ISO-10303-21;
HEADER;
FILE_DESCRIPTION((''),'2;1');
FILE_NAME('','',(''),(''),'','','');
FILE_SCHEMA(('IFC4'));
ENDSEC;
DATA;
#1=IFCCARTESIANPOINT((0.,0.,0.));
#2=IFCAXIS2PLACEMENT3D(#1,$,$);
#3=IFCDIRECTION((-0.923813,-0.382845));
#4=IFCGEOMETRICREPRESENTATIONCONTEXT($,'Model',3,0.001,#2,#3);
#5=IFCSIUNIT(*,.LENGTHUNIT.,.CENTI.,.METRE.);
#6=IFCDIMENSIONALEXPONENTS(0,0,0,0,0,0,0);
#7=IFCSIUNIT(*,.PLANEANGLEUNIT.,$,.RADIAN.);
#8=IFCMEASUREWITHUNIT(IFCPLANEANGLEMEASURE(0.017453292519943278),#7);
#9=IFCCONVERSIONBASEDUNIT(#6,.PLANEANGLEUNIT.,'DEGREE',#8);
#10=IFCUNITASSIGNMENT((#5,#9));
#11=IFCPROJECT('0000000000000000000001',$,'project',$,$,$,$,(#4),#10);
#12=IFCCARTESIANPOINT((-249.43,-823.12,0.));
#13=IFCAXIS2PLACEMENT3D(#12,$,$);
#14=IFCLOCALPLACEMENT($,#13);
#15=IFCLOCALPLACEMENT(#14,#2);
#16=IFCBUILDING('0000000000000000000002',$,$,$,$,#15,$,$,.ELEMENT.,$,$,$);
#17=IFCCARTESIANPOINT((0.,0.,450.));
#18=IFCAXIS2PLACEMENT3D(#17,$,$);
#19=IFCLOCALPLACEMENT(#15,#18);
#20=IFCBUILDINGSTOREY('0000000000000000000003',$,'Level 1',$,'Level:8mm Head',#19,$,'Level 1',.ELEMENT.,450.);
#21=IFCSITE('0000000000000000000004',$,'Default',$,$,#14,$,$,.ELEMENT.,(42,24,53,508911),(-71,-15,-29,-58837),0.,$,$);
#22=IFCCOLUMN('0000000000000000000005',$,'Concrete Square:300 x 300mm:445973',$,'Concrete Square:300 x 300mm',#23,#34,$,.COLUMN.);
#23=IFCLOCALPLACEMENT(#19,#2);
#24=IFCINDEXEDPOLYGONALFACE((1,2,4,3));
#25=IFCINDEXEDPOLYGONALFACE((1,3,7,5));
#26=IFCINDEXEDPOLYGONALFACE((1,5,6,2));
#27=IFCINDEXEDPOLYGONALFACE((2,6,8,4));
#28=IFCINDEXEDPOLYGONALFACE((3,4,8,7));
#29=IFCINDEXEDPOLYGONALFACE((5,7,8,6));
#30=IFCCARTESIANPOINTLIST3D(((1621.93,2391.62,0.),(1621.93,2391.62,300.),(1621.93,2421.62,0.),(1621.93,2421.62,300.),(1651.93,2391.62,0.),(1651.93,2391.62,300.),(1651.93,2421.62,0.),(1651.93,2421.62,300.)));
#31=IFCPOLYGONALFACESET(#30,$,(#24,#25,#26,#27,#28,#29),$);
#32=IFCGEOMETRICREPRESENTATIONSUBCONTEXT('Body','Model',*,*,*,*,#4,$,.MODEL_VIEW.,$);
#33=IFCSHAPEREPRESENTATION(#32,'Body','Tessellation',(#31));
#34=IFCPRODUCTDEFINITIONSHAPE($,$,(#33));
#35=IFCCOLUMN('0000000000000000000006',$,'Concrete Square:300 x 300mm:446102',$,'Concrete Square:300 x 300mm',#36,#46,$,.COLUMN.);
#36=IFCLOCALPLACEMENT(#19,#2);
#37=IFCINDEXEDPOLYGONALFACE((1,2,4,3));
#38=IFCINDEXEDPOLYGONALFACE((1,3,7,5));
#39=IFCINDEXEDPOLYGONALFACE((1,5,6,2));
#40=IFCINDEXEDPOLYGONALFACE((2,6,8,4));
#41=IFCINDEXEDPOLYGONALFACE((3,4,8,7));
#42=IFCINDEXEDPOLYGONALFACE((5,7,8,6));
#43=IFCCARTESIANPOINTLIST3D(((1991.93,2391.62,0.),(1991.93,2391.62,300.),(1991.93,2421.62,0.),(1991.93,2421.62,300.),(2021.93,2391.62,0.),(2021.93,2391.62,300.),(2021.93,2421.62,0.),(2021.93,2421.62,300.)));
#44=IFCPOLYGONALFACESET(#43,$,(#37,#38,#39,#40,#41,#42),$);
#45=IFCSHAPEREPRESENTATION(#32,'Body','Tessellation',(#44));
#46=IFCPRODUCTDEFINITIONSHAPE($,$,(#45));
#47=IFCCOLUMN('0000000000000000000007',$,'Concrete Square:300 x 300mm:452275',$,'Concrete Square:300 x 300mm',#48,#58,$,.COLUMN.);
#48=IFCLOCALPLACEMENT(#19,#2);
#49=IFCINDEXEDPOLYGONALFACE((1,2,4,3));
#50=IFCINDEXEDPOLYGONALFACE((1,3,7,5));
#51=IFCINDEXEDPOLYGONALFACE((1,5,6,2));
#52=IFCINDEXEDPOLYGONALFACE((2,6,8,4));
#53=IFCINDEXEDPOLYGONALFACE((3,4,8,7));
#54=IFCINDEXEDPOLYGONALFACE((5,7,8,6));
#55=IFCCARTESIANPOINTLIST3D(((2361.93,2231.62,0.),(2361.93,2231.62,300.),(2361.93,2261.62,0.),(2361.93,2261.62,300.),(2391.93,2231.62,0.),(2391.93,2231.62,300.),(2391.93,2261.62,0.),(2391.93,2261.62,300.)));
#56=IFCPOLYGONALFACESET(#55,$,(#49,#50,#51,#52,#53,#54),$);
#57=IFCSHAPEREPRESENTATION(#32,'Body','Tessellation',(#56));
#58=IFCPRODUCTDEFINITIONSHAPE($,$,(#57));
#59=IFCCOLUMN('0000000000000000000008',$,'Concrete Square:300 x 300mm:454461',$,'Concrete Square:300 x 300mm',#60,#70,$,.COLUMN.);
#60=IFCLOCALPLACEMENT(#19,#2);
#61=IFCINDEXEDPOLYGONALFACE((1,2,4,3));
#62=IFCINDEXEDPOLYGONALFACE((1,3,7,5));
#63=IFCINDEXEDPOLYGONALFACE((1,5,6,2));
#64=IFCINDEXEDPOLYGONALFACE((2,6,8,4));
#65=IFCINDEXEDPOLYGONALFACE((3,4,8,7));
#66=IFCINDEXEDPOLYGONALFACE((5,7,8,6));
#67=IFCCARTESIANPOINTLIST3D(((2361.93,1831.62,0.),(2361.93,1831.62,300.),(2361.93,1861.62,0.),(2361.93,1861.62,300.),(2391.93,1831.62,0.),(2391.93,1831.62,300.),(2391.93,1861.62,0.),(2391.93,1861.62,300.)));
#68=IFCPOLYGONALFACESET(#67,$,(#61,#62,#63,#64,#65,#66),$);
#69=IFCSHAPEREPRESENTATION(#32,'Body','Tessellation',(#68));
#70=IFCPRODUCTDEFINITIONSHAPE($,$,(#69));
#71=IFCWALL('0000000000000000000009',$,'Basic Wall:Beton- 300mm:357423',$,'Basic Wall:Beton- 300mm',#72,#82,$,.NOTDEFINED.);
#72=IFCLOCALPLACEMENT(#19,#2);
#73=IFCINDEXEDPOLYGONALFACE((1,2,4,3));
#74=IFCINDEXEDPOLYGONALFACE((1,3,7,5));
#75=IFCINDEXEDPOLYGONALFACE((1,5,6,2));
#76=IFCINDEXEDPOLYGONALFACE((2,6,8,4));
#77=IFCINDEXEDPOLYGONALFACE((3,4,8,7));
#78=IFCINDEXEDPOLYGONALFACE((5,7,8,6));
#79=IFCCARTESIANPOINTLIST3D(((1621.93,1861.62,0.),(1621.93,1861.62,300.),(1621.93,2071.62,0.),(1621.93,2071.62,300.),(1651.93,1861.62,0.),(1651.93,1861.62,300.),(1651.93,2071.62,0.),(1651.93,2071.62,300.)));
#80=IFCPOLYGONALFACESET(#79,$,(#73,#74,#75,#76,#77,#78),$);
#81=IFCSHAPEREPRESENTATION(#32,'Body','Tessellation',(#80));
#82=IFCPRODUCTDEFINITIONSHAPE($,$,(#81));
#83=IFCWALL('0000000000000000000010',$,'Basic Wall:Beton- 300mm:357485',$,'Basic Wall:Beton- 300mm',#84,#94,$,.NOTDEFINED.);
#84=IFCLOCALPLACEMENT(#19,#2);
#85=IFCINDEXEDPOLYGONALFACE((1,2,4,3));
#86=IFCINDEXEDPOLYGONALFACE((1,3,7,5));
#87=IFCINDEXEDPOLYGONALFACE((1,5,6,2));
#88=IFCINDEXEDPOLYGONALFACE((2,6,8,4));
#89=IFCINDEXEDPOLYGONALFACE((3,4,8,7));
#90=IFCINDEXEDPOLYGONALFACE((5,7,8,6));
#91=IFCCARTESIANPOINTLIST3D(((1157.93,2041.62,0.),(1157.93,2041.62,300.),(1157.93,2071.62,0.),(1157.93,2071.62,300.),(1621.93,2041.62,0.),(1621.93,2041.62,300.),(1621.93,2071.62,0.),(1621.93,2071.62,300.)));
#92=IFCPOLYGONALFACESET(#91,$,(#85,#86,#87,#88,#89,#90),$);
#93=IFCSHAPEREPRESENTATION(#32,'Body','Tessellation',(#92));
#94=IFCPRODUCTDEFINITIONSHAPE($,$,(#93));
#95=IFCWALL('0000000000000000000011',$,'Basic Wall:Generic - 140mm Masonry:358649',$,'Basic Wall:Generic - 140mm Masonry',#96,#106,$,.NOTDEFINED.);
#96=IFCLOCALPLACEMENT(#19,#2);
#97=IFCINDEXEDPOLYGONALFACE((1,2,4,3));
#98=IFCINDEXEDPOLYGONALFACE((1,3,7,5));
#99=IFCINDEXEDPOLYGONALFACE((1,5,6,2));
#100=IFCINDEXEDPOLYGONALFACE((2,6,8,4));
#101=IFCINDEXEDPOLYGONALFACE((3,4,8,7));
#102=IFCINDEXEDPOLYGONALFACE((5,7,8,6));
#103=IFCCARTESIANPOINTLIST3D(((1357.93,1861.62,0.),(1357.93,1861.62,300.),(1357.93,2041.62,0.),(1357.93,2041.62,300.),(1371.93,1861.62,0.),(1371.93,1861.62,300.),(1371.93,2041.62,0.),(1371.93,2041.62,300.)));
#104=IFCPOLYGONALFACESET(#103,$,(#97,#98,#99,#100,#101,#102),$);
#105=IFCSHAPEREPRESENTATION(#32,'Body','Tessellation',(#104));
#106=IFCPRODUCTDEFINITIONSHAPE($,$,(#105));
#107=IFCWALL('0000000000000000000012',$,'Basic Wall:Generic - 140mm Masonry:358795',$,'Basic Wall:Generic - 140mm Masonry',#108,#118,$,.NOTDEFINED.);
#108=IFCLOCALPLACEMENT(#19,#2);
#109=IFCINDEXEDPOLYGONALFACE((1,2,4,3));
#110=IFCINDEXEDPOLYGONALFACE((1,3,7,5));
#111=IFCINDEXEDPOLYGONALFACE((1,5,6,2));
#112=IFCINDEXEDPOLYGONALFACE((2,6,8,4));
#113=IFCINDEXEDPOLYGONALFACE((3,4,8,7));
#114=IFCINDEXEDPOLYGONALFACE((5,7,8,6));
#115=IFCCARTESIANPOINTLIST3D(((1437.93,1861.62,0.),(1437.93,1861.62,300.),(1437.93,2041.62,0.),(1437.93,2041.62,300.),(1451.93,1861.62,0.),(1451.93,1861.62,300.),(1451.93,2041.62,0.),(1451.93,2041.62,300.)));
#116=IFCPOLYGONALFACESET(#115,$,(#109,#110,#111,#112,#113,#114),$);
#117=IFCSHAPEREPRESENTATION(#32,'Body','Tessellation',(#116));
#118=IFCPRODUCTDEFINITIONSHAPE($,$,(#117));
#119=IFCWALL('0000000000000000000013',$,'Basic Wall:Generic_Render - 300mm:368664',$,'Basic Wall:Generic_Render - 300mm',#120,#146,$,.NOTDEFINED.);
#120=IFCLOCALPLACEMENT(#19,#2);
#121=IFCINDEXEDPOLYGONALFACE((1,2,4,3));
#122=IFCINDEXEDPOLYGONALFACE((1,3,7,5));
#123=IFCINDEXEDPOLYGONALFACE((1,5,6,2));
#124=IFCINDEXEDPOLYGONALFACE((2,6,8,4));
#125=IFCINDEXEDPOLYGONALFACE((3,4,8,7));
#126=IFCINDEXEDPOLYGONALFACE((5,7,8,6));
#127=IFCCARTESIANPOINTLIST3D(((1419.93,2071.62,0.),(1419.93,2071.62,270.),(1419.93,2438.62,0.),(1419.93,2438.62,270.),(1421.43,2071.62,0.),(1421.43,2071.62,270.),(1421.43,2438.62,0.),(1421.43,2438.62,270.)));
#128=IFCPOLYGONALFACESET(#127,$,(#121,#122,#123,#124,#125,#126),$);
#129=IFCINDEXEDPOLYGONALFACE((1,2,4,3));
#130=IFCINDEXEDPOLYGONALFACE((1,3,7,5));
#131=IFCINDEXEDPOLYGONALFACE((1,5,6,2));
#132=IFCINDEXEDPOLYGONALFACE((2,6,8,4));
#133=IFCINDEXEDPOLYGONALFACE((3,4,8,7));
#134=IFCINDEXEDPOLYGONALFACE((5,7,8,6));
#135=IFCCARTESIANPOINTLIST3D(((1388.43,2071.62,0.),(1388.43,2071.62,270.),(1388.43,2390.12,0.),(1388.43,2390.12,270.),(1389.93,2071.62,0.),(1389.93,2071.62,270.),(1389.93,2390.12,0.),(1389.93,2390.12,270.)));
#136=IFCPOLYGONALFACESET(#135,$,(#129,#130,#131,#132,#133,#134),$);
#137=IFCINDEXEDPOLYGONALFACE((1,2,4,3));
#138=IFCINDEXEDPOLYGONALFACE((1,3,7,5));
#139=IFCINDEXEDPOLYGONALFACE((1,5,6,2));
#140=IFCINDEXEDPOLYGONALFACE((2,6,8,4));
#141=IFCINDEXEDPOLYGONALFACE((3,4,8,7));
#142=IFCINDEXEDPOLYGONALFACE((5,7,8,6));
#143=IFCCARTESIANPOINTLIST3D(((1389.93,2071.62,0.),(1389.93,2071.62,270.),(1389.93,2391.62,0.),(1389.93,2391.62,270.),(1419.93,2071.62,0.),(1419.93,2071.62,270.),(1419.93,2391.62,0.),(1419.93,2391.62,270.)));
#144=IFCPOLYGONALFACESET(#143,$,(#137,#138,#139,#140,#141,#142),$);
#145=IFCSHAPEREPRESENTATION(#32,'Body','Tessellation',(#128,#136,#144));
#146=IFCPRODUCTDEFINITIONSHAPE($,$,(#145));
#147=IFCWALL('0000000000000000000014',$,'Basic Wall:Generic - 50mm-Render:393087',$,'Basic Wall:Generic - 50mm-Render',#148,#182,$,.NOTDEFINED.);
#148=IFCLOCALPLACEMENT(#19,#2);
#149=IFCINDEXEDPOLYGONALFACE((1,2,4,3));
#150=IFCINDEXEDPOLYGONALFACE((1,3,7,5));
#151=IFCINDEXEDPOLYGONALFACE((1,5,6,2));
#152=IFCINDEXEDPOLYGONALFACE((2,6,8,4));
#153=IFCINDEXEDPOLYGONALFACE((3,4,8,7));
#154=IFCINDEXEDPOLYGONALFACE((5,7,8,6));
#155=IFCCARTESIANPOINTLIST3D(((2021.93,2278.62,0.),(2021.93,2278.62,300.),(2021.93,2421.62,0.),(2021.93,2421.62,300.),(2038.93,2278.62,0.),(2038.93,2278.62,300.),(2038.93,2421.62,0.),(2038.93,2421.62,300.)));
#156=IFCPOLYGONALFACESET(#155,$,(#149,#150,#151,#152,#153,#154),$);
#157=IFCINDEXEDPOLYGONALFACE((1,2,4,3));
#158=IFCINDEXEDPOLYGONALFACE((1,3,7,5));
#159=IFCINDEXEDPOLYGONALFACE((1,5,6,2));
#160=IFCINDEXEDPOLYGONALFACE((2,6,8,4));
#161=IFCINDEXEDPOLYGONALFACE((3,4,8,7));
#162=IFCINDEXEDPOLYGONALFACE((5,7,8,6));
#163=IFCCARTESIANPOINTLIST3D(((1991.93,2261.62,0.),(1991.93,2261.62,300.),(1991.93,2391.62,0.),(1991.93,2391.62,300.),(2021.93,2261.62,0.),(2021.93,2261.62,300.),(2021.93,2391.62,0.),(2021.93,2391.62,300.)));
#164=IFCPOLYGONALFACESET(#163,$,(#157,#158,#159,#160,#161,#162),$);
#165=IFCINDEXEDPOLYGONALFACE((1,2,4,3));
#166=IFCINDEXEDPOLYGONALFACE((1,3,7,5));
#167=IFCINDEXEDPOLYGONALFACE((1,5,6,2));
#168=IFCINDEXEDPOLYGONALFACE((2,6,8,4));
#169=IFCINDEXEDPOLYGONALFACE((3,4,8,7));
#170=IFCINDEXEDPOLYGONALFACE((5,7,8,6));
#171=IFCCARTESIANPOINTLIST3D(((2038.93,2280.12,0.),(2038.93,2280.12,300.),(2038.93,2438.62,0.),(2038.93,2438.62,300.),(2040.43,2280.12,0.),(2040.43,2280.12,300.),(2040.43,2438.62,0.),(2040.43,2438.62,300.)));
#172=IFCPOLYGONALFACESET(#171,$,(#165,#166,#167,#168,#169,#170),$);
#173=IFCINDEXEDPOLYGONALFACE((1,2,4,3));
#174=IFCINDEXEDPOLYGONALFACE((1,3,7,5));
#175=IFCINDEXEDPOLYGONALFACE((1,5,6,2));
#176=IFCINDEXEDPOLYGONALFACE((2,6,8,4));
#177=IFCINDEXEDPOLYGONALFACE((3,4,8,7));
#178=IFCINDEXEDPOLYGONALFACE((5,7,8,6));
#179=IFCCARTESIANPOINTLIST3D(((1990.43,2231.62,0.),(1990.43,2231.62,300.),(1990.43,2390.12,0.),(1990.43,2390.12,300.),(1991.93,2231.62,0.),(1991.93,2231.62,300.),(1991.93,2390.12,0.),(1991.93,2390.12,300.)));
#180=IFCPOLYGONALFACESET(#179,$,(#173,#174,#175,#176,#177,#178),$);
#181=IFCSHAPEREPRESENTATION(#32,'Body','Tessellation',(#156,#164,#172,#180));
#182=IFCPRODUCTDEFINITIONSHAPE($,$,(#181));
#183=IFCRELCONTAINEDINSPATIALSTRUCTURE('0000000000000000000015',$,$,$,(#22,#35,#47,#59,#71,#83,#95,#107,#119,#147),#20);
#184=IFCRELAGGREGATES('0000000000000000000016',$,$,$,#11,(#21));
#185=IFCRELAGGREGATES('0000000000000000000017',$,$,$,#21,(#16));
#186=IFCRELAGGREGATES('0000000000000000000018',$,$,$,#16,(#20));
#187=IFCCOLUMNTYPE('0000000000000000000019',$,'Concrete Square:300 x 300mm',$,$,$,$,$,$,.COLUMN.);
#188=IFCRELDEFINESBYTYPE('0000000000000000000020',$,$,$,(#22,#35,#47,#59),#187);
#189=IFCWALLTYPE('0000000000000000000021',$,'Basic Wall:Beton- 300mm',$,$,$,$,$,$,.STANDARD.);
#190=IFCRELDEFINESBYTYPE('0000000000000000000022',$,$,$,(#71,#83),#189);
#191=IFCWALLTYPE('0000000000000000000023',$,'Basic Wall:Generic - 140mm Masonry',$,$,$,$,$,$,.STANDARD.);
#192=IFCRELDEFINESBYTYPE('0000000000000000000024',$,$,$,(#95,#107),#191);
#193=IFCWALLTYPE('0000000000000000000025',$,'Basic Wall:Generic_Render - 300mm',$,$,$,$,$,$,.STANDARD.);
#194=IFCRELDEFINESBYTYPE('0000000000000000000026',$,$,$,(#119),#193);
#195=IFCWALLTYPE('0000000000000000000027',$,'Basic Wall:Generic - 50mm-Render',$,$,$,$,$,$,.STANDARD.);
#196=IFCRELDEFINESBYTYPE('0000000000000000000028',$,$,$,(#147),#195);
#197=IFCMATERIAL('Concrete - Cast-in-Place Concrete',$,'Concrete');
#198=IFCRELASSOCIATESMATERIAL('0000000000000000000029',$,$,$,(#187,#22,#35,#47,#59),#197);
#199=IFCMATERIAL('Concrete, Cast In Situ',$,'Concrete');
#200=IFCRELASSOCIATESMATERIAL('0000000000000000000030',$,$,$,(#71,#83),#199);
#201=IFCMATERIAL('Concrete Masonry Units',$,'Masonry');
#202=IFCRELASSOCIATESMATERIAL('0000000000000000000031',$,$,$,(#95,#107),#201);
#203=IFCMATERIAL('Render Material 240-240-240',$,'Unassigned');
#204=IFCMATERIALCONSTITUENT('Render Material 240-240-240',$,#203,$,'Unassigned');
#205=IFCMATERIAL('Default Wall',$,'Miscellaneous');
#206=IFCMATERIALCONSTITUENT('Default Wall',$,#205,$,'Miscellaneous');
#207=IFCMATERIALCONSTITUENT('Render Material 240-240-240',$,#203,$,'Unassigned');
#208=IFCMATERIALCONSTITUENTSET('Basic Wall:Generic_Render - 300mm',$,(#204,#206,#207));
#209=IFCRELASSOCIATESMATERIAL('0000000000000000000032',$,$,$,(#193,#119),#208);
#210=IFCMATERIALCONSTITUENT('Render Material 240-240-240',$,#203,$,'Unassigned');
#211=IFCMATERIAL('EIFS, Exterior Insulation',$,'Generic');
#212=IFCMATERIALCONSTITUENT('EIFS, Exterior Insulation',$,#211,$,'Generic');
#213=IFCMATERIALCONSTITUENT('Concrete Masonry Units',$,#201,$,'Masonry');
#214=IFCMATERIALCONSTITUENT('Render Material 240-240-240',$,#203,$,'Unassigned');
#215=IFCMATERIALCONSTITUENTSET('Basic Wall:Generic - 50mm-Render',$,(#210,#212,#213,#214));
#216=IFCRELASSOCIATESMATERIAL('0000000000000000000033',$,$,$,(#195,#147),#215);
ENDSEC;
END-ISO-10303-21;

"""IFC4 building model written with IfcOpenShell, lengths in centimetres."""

from ifc_helpers import new_model, entity, si_unit, converted_unit, direction, frame, origin, place, context, subcontext, project, spatial, indexed_curve, outline, extrude, source, transform, mapped, material, constituent, constituent_set, type_object, type_shapes, element, save


model = new_model("IFC4")

# Units and contexts
model_context = context("Model", 3, precision=0.001, world=origin(), true_north=direction((-0.923813, -0.382845)))
body_context = subcontext(model_context, "Body", "Model", "MODEL_VIEW")
ifc_project = project(units=[si_unit("LENGTHUNIT", "METRE", prefix="CENTI"), converted_unit("PLANEANGLEUNIT", "DEGREE", entity("IfcPlaneAngleMeasure", 0.017453292519943278), si_unit("PLANEANGLEUNIT", "RADIAN"), dimensions=[0, 0, 0, 0, 0, 0, 0])], contexts=[model_context])

# Site, building, storey
site_placement = place(None, frame((-249.43, -823.12, 0.0)))
site = spatial("IfcSite", under=ifc_project, at=site_placement, Name="Default", CompositionType="ELEMENT", RefLatitude=(42, 24, 53, 508911), RefLongitude=(-71, -15, -29, -58837), RefElevation=0.0)
building_placement = place(site_placement, origin())
building = spatial("IfcBuilding", under=site, at=building_placement, CompositionType="ELEMENT")
storey_placement = place(building_placement, frame((0.0, 0.0, 450.0)))
storey = spatial("IfcBuildingStorey", under=building, at=storey_placement, Name="Level 1", ObjectType="Level:8mm Head", LongName="Level 1", CompositionType="ELEMENT", Elevation=450.0)

# Columns
ifc_material_1 = material(Name="Concrete - Cast-in-Place Concrete", Category="Concrete")
column_type = type_object("IfcColumnType", Name="Concrete Square:300 x 300mm", PredefinedType="COLUMN", material=ifc_material_1)
shared_shape_1 = source(origin(), body_context, "Body", "SweptSolid", [
    extrude(outline(indexed_curve([(-15.0, -15.0), (15.0, -15.0), (15.0, 15.0), (-15.0, 15.0), (-15.0, -15.0)], self_intersect=False)), frame((0.0, 0.0, 450.0), z_axis=(0.0, 0.0, 1.0), x_axis=(-1.0, 0.0, 0.0)), (0.0, 0.0, 1.0), 300.0),
])
type_shapes(column_type, [shared_shape_1])
for number, where, name in (
    (1, (1636.93, 2406.62, -450.0), "Concrete Square:300 x 300mm:445973"),
    (2, (2006.93, 2406.62, -450.0), "Concrete Square:300 x 300mm:446102"),
    (3, (2376.93, 2246.62, -450.0), "Concrete Square:300 x 300mm:452275"),
    (4, (2376.93, 1846.62, -450.0), "Concrete Square:300 x 300mm:454461"),
):
    element("IfcColumn", number, at=place(storey_placement, frame(where)), inside=storey, type_object=column_type, material=ifc_material_1, Name=name, ObjectType="Concrete Square:300 x 300mm", PredefinedType="COLUMN", context=body_context, shape_type="MappedRepresentation", body=[
        mapped(shared_shape_1, transform((0.0, 0.0, 0.0), scale=1.0)),
    ])

# Walls
ifc_material_2 = material(Name="Concrete, Cast In Situ", Category="Concrete")
wall_type_1 = type_object("IfcWallType", Name="Basic Wall:Beton- 300mm", PredefinedType="STANDARD")
wall_1_placement = place(storey_placement, frame((1636.93, 1861.62, 0.0), z_axis=(0.0, 0.0, 1.0), x_axis=(0.0, 1.0, 0.0)))
element("IfcWall", 5, at=wall_1_placement, inside=storey, type_object=wall_type_1, material=ifc_material_2, Name="Basic Wall:Beton- 300mm:357423", ObjectType="Basic Wall:Beton- 300mm", PredefinedType="NOTDEFINED", context=body_context, shape_type="SweptSolid", body=[
    extrude(outline(indexed_curve([(210.0, 15.0), (0.0, 15.0), (0.0, -15.0), (210.0, -15.0), (210.0, 15.0)], self_intersect=False)), origin(), (0.0, 0.0, 1.0), 300.0),
])
wall_2_placement = place(storey_placement, frame((1621.93, 2056.62, 0.0), z_axis=(0.0, 0.0, 1.0), x_axis=(-1.0, 0.0, 0.0)))
element("IfcWall", 6, at=wall_2_placement, inside=storey, type_object=wall_type_1, material=ifc_material_2, Name="Basic Wall:Beton- 300mm:357485", ObjectType="Basic Wall:Beton- 300mm", PredefinedType="NOTDEFINED", context=body_context, shape_type="SweptSolid", body=[
    extrude(outline(indexed_curve([(464.0, 15.0), (0.0, 15.0), (0.0, -15.0), (464.0, -15.0), (464.0, 15.0)], self_intersect=False)), origin(), (0.0, 0.0, 1.0), 300.0),
])
ifc_material_3 = material(Name="Concrete Masonry Units", Category="Masonry")
wall_type_2 = type_object("IfcWallType", Name="Basic Wall:Generic - 140mm Masonry", PredefinedType="STANDARD")
wall_3_placement = place(storey_placement, frame((1364.93, 2041.62, 0.0), z_axis=(0.0, 0.0, 1.0), x_axis=(0.0, -1.0, 0.0)))
element("IfcWall", 7, at=wall_3_placement, inside=storey, type_object=wall_type_2, material=ifc_material_3, Name="Basic Wall:Generic - 140mm Masonry:358649", ObjectType="Basic Wall:Generic - 140mm Masonry", PredefinedType="NOTDEFINED", context=body_context, shape_type="SweptSolid", body=[
    extrude(outline(indexed_curve([(180.0, 7.0), (0.0, 7.0), (0.0, -7.0), (180.0, -7.0), (180.0, 7.0)], self_intersect=False)), origin(), (0.0, 0.0, 1.0), 300.0),
])
wall_4_placement = place(storey_placement, frame((1444.93, 2041.62, 0.0), z_axis=(0.0, 0.0, 1.0), x_axis=(0.0, -1.0, 0.0)))
element("IfcWall", 8, at=wall_4_placement, inside=storey, type_object=wall_type_2, material=ifc_material_3, Name="Basic Wall:Generic - 140mm Masonry:358795", ObjectType="Basic Wall:Generic - 140mm Masonry", PredefinedType="NOTDEFINED", context=body_context, shape_type="SweptSolid", body=[
    extrude(outline(indexed_curve([(180.0, 7.0), (0.0, 7.0), (0.0, -7.0), (180.0, -7.0), (180.0, 7.0)], self_intersect=False)), origin(), (0.0, 0.0, 1.0), 300.0),
])
ifc_material_4 = material(Name="Render Material 240-240-240", Category="Unassigned")
ifc_constituent_1 = constituent(ifc_material_4, Name="Render Material 240-240-240", Category="Unassigned")
ifc_material_5 = material(Name="Default Wall", Category="Miscellaneous")
ifc_constituent_2 = constituent(ifc_material_5, Name="Default Wall", Category="Miscellaneous")
ifc_constituent_3 = constituent(ifc_material_4, Name="Render Material 240-240-240", Category="Unassigned")
ifc_constituent_set_1 = constituent_set(constituents=[ifc_constituent_1, ifc_constituent_2, ifc_constituent_3], Name="Basic Wall:Generic_Render - 300mm")
wall_type_3 = type_object("IfcWallType", Name="Basic Wall:Generic_Render - 300mm", PredefinedType="STANDARD", material=ifc_constituent_set_1)
wall_5_placement = place(storey_placement, frame((1404.93, 2071.62, 0.0), z_axis=(0.0, 0.0, 1.0), x_axis=(0.0, 1.0, 0.0)))
element("IfcWall", 9, at=wall_5_placement, inside=storey, type_object=wall_type_3, material=ifc_constituent_set_1, Name="Basic Wall:Generic_Render - 300mm:368664", ObjectType="Basic Wall:Generic_Render - 300mm", PredefinedType="NOTDEFINED", context=body_context, shape_type="SweptSolid", body=[
    extrude(outline(indexed_curve([(-0.75, -183.5), (0.75, -183.5), (0.75, 183.5), (-0.75, 183.5), (-0.75, -183.5)], self_intersect=False)), frame((183.5, -15.75, 0.0), z_axis=(0.0, 0.0, 1.0), x_axis=(0.0, 1.0, 0.0)), (0.0, 0.0, 1.0), 270.0),
    extrude(outline(indexed_curve([(-0.75, -159.25), (0.75, -159.25), (0.75, 159.25), (-0.75, 159.25), (-0.75, -159.25)], self_intersect=False)), frame((159.25, 15.75, 0.0), z_axis=(0.0, 0.0, 1.0), x_axis=(0.0, -1.0, 0.0)), (0.0, 0.0, 1.0), 270.0),
    extrude(outline(indexed_curve([(-160.0, -15.0), (160.0, -15.0), (160.0, 15.0), (-160.0, 15.0), (-160.0, -15.0)], self_intersect=False)), frame((160.0, 0.0, 0.0)), (0.0, 0.0, 1.0), 270.0),
])
ifc_constituent_4 = constituent(ifc_material_4, Name="Render Material 240-240-240", Category="Unassigned")
ifc_material_6 = material(Name="EIFS, Exterior Insulation", Category="Generic")
ifc_constituent_5 = constituent(ifc_material_6, Name="EIFS, Exterior Insulation", Category="Generic")
ifc_constituent_6 = constituent(ifc_material_3, Name="Concrete Masonry Units", Category="Masonry")
ifc_constituent_7 = constituent(ifc_material_4, Name="Render Material 240-240-240", Category="Unassigned")
ifc_constituent_set_2 = constituent_set(constituents=[ifc_constituent_4, ifc_constituent_5, ifc_constituent_6, ifc_constituent_7], Name="Basic Wall:Generic - 50mm-Render")
wall_type_4 = type_object("IfcWallType", Name="Basic Wall:Generic - 50mm-Render", PredefinedType="STANDARD", material=ifc_constituent_set_2)
wall_6_placement = place(storey_placement, frame((2015.43, 2280.12, 0.0), z_axis=(0.0, 0.0, 1.0), x_axis=(0.0, 1.0, 0.0)))
element("IfcWall", 10, at=wall_6_placement, inside=storey, type_object=wall_type_4, material=ifc_constituent_set_2, Name="Basic Wall:Generic - 50mm-Render:393087", ObjectType="Basic Wall:Generic - 50mm-Render", PredefinedType="NOTDEFINED", context=body_context, shape_type="SweptSolid", body=[
    extrude(outline(indexed_curve([(-8.5, -71.5), (8.5, -71.5), (8.5, 71.5), (-8.5, 71.5), (-8.5, -71.5)], self_intersect=False)), frame((70.0, -15.0, 0.0), z_axis=(0.0, 0.0, 1.0), x_axis=(0.0, 1.0, 0.0)), (0.0, 0.0, 1.0), 300.0),
    extrude(outline(indexed_curve([(-15.0, -65.0), (15.0, -65.0), (15.0, 65.0), (-15.0, 65.0), (-15.0, -65.0)], self_intersect=False)), frame((46.5, 8.5, 0.0), z_axis=(0.0, 0.0, 1.0), x_axis=(0.0, -1.0, 0.0)), (0.0, 0.0, 1.0), 300.0),
    extrude(outline(indexed_curve([(-0.75, -79.25), (0.75, -79.25), (0.75, 79.25), (-0.75, 79.25), (-0.75, -79.25)], self_intersect=False)), frame((79.25, -24.25, 0.0), z_axis=(0.0, 0.0, 1.0), x_axis=(0.0, 1.0, 0.0)), (0.0, 0.0, 1.0), 300.0),
    extrude(outline(indexed_curve([(-0.75, -79.25), (0.75, -79.25), (0.75, 79.25), (-0.75, 79.25), (-0.75, -79.25)], self_intersect=False)), frame((30.75, 24.25, 0.0), z_axis=(0.0, 0.0, 1.0), x_axis=(0.0, 1.0, 0.0)), (0.0, 0.0, 1.0), 300.0),
])

save(model, "model.ifc")
